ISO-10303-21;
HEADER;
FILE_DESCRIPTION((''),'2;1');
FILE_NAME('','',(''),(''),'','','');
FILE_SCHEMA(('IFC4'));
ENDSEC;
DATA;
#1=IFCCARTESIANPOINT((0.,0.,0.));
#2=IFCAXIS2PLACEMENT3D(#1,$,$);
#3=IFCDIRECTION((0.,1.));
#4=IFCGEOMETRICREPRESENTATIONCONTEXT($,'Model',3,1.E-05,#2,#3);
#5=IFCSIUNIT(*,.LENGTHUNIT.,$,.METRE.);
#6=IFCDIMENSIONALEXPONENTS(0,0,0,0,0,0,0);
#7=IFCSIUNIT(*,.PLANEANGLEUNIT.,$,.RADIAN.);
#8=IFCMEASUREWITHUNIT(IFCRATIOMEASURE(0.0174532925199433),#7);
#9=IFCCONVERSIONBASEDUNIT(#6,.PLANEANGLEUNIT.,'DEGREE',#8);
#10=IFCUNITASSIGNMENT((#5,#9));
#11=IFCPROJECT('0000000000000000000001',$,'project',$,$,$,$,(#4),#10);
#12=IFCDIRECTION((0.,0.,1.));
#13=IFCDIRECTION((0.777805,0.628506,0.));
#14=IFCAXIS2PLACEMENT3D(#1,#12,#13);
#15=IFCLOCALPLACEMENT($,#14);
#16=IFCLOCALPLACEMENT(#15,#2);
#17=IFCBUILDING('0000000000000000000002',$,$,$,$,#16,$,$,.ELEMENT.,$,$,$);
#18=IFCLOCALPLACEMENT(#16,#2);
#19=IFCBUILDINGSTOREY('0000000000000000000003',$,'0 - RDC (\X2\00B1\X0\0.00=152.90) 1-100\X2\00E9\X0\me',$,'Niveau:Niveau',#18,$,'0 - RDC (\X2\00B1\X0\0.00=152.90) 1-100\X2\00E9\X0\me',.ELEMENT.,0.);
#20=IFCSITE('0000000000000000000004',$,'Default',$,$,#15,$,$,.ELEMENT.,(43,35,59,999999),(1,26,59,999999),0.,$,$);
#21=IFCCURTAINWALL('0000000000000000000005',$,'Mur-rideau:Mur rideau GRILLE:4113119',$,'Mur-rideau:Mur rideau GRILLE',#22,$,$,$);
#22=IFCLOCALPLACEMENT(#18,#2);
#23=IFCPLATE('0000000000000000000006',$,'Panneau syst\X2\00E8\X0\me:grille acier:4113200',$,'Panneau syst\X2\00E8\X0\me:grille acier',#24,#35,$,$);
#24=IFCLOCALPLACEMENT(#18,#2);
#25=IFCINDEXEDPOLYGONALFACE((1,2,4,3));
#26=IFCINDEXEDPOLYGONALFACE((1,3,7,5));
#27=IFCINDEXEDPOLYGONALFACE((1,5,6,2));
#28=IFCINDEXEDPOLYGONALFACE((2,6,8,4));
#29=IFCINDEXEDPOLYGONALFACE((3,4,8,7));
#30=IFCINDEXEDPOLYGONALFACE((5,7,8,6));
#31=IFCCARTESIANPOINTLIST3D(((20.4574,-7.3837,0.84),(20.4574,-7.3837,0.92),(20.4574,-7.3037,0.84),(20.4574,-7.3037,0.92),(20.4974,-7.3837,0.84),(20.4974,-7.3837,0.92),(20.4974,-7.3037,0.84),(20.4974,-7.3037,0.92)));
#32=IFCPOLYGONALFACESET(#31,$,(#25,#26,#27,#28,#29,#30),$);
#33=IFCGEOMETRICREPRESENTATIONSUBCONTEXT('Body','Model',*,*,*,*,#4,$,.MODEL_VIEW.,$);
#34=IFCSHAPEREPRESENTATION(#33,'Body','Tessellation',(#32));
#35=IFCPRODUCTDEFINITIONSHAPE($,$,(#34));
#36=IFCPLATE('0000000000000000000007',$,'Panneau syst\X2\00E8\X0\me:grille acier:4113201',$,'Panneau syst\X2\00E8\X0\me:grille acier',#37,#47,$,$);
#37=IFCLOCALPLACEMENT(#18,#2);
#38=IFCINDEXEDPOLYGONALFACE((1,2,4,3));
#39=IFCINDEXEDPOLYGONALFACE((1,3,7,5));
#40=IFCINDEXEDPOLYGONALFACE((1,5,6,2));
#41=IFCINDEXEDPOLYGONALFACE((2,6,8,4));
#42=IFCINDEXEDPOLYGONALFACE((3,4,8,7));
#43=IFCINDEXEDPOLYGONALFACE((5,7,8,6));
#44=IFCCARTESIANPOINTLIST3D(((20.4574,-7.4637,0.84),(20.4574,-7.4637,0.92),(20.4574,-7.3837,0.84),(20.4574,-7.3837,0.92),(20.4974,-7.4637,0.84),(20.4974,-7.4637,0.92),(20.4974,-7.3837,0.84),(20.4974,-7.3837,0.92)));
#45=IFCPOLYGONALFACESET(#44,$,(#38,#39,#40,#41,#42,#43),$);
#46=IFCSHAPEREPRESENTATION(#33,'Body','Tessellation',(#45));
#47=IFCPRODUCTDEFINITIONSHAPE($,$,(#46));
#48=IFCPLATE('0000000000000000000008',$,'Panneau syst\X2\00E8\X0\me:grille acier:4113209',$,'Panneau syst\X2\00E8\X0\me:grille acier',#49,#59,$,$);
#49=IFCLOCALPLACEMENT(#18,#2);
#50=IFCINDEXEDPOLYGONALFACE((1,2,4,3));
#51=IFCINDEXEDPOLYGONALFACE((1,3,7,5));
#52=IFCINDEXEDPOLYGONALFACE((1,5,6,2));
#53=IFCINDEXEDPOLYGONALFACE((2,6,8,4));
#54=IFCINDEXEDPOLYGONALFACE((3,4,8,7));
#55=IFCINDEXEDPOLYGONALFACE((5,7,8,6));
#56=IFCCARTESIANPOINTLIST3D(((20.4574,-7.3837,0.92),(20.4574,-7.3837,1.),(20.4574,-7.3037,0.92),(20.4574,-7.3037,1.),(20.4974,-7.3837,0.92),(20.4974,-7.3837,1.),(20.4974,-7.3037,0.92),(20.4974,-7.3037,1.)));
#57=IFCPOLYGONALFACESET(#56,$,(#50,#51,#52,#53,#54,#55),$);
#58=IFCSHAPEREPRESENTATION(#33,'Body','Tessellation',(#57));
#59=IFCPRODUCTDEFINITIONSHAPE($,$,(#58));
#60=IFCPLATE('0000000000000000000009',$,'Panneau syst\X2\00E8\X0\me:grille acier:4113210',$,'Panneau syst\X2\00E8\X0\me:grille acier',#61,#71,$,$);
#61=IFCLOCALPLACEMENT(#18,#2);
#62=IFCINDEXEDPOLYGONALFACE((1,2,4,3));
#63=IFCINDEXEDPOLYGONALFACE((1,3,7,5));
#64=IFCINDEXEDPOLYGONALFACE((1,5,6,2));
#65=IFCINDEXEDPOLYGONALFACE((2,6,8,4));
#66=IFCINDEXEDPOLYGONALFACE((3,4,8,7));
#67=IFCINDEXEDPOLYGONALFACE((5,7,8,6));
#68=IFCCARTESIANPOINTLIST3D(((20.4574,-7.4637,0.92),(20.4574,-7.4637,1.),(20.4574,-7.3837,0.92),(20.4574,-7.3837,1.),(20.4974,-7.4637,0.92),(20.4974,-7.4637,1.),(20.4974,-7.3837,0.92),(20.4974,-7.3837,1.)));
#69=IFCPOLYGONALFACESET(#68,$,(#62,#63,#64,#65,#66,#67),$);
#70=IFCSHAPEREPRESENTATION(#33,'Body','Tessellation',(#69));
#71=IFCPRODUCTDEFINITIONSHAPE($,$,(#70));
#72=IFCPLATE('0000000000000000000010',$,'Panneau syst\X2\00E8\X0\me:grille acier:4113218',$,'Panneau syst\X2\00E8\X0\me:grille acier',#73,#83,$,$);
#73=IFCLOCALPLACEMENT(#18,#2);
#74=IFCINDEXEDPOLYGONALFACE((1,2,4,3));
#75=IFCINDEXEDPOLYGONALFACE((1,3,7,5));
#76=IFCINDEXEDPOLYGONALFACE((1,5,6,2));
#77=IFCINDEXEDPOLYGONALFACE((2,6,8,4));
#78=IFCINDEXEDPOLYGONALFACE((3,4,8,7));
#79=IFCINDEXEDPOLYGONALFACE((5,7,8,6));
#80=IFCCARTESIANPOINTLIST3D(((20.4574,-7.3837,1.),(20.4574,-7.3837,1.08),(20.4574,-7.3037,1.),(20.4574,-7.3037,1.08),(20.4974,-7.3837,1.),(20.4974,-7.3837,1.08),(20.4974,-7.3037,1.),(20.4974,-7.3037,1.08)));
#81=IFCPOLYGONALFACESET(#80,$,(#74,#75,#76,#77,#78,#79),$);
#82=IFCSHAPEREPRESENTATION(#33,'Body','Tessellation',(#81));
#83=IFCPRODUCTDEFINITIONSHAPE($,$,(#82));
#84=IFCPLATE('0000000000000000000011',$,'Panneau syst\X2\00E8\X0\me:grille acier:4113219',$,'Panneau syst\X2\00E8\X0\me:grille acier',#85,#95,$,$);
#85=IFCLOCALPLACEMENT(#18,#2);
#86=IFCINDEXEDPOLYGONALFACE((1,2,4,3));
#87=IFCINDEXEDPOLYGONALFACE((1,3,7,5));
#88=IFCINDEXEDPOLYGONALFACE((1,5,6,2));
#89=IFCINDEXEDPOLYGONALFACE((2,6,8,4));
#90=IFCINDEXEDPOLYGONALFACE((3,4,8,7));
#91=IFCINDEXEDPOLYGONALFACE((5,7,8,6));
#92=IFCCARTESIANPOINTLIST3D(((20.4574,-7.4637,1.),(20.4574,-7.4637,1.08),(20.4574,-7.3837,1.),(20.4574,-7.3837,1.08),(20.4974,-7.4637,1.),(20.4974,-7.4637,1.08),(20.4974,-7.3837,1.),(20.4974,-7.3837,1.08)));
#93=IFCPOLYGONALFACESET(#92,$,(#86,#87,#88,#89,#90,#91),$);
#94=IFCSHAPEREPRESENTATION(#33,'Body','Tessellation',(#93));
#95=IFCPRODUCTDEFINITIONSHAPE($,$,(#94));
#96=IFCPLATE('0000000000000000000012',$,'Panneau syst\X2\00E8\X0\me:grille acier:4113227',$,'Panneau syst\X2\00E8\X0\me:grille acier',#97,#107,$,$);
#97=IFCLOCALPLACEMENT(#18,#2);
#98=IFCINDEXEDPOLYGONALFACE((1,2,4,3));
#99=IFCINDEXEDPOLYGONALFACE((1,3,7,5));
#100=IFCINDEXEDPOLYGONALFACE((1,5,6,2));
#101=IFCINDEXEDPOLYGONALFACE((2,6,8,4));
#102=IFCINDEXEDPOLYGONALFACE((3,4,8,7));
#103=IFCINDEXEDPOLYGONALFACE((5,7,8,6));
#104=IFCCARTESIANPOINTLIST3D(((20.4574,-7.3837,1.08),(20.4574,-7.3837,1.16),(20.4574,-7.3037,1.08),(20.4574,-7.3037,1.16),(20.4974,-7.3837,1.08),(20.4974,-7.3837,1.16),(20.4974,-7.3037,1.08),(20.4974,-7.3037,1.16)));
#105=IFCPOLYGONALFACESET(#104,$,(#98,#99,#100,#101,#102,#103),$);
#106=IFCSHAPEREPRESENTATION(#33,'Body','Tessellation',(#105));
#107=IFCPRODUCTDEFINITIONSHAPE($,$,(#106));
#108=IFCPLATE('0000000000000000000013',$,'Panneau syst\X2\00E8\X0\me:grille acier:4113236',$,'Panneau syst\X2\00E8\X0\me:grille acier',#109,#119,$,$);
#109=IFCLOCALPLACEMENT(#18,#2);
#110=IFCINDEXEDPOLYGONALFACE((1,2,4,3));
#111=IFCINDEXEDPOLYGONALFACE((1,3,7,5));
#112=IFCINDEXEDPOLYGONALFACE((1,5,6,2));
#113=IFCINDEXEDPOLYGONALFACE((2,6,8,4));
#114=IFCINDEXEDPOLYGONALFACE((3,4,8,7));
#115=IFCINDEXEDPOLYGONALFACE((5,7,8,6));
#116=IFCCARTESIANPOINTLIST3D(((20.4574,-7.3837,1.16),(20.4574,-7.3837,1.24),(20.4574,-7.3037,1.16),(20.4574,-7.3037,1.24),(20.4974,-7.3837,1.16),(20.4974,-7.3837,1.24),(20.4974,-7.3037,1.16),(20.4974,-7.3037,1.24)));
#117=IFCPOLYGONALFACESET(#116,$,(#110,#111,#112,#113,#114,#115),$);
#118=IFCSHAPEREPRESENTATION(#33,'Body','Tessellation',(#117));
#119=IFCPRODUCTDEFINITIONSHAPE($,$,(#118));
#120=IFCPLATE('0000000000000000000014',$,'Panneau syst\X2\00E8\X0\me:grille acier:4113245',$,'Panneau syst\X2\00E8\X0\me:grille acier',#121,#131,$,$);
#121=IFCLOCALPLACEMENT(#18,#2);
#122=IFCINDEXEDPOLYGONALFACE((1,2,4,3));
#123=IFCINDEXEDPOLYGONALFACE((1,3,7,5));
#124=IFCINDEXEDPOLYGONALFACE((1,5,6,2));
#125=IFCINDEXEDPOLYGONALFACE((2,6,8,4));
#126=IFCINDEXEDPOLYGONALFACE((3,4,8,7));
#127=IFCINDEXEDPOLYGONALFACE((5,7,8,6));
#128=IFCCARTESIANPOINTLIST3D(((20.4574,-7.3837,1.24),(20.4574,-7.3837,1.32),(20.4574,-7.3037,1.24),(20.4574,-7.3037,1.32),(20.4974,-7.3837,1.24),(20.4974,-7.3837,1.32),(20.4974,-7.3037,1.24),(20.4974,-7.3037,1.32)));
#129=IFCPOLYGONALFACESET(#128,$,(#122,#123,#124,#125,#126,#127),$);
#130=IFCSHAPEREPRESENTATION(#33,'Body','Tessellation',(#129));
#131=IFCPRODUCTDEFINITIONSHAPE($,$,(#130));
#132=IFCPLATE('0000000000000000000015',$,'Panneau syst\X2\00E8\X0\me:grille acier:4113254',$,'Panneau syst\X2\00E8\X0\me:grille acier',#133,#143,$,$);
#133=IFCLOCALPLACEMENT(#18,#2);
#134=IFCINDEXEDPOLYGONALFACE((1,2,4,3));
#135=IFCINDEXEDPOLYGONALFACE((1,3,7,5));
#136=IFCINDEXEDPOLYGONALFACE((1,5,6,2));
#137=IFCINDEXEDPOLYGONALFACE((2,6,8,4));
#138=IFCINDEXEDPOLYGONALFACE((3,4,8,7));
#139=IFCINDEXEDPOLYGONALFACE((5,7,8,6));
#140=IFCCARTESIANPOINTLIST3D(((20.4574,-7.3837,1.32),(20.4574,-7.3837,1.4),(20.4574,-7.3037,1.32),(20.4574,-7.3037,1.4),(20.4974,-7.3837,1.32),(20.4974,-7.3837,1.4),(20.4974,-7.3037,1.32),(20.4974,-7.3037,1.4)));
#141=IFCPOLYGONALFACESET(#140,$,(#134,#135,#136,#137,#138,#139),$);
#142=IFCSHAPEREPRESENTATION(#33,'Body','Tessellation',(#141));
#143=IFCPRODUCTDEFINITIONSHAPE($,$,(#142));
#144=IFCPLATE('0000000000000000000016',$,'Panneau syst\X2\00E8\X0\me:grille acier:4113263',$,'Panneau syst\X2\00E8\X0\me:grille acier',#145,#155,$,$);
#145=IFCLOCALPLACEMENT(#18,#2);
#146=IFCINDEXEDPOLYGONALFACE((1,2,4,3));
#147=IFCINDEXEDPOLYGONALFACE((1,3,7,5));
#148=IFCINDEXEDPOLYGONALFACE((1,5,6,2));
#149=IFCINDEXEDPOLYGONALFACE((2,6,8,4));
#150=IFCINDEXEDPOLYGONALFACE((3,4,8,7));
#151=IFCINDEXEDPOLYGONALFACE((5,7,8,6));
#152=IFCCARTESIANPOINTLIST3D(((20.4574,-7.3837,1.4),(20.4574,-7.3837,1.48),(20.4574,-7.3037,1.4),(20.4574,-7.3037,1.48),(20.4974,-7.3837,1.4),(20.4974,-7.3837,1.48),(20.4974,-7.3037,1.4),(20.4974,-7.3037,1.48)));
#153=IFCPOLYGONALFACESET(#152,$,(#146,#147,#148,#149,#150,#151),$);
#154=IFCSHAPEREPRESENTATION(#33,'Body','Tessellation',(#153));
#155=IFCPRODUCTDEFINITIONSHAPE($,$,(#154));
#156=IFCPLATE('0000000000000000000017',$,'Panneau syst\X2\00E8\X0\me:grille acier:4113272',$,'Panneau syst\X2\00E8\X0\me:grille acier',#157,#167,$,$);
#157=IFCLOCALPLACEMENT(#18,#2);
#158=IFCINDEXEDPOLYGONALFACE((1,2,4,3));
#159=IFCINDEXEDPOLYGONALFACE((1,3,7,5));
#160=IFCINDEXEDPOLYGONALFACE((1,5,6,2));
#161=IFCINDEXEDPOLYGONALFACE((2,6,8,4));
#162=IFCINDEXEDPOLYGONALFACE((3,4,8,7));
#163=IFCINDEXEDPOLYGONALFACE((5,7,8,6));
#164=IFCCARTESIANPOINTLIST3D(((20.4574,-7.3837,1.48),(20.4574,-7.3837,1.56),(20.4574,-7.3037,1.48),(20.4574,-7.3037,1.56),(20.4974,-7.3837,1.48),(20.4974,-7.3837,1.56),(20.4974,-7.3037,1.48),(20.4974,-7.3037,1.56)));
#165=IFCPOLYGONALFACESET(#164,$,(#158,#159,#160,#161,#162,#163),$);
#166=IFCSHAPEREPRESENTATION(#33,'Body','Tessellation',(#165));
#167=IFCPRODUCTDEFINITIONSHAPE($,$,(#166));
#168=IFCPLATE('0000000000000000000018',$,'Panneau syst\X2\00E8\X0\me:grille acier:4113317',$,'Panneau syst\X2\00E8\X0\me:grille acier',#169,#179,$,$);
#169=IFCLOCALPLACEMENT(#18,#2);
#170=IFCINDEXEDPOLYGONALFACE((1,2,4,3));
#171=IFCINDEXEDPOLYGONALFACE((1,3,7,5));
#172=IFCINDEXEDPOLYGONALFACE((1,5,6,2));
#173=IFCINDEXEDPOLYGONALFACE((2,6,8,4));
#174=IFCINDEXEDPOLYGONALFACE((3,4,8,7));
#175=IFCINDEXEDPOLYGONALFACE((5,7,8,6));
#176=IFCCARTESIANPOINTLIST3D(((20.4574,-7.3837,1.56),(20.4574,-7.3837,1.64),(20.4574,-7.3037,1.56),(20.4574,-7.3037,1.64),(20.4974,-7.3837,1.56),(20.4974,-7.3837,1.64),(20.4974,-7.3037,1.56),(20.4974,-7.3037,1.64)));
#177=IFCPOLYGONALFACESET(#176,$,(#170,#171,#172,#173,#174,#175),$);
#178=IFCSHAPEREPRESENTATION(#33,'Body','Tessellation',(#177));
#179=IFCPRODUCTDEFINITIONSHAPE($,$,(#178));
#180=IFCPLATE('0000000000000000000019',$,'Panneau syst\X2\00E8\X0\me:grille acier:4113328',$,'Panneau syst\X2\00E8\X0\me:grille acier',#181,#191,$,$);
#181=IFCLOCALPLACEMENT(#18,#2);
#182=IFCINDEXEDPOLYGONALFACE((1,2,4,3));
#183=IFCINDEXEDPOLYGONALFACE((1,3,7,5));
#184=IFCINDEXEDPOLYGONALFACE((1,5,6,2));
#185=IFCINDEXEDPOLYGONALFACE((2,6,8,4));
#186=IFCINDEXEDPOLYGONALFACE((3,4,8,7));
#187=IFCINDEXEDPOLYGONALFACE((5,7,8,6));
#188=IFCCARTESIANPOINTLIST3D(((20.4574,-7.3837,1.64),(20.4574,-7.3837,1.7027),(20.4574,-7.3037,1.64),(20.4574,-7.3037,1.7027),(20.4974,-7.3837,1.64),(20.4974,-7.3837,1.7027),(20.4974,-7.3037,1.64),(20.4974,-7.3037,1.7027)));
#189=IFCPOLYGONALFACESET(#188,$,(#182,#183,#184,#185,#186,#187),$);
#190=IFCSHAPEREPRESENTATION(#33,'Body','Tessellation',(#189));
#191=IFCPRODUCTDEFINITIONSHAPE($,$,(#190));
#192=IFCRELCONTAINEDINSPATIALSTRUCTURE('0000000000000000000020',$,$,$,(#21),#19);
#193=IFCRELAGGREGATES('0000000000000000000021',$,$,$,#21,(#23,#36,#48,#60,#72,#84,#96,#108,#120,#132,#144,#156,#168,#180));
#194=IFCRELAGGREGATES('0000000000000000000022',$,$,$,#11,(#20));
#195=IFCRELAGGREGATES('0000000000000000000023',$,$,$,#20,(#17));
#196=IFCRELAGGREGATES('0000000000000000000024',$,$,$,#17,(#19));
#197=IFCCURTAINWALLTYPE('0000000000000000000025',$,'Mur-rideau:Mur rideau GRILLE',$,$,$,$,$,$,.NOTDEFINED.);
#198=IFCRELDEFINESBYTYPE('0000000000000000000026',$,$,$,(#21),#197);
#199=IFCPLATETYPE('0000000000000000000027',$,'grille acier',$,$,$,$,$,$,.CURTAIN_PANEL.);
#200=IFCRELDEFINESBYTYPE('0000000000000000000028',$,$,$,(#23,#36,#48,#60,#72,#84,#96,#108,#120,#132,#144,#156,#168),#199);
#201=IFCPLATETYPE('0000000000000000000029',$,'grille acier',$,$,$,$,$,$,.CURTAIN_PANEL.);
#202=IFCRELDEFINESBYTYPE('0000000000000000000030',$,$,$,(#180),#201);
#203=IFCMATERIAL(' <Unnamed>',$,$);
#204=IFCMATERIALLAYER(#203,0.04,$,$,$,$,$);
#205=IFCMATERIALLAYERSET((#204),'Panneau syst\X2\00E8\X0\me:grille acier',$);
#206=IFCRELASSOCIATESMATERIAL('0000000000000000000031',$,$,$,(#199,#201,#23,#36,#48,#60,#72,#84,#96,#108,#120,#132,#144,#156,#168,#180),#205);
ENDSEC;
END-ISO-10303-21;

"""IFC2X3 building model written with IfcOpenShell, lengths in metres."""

from ifc_helpers import new_model, entity, si_unit, converted_unit, direction, frame, origin, origin_2d_with_axis, place, context, subcontext, project, spatial, rectangle, extrude, source, transform, mapped, material, layer, layer_set, layer_usage, type_object, type_shapes, element, aggregate, save


model = new_model("IFC2X3")

# Units and contexts
model_context = context("Model", 3, precision=1e-05, world=origin(), true_north=direction((0.0, 1.0)))
body_context = subcontext(model_context, "Body", "Model", "MODEL_VIEW")
ifc_project = project(units=[si_unit("LENGTHUNIT", "METRE"), converted_unit("PLANEANGLEUNIT", "DEGREE", entity("IfcRatioMeasure", 0.0174532925199433), si_unit("PLANEANGLEUNIT", "RADIAN"), dimensions=[0, 0, 0, 0, 0, 0, 0])], contexts=[model_context])

# Site, building, storey
site_placement = place(None, frame((0.0, 0.0, 0.0), z_axis=(0.0, 0.0, 1.0), x_axis=(0.777805, 0.628506, 0.0)))
site = spatial("IfcSite", under=ifc_project, at=site_placement, Name="Default", CompositionType="ELEMENT", RefLatitude=(43, 35, 59, 999999), RefLongitude=(1, 26, 59, 999999), RefElevation=0.0)
building_placement = place(site_placement, origin())
building = spatial("IfcBuilding", under=site, at=building_placement, CompositionType="ELEMENT")
storey_placement = place(building_placement, origin())
storey = spatial("IfcBuildingStorey", under=building, at=storey_placement, Name="0 - RDC (±0.00=152.90) 1-100éme", ObjectType="Niveau:Niveau", LongName="0 - RDC (±0.00=152.90) 1-100éme", CompositionType="ELEMENT", Elevation=0.0)

# Curtain wall, plates
curtain_wall_type = type_object("IfcCurtainWallType", Name="Mur-rideau:Mur rideau GRILLE", PredefinedType="NOTDEFINED")
curtain_wall_placement = place(storey_placement, origin())
curtain_wall = element("IfcCurtainWall", 1, at=curtain_wall_placement, inside=storey, type_object=curtain_wall_type, Name="Mur-rideau:Mur rideau GRILLE:4113119", ObjectType="Mur-rideau:Mur rideau GRILLE")
ifc_material = material(Name=" <Unnamed>")
ifc_layer = layer(ifc_material, 0.04)
ifc_layer_set = layer_set([ifc_layer], Name="Panneau système:grille acier")
plate_type_1 = type_object("IfcPlateType", Name="grille acier", PredefinedType="CURTAIN_PANEL", material=ifc_layer_set)
shared_shape_1 = source(origin(), body_context, "Body", "SweptSolid", [
    extrude(rectangle(XDim=0.04, YDim=0.08, at=origin_2d_with_axis()), frame((0.0, 0.0, 0.0), z_axis=(0.0, 0.0, 1.0), x_axis=(0.0, 1.0, 0.0)), (0.0, 0.0, 1.0), 0.08),
])
type_shapes(plate_type_1, [shared_shape_1])
ifc_layer_usage_1 = layer_usage(ifc_layer_set, "AXIS3", "POSITIVE", 0.0)
plate_1_placement = place(curtain_wall_placement, frame((20.4774, -7.3437, 0.84), z_axis=(0.0, 0.0, 1.0), x_axis=(0.0, -1.0, 0.0)))
plate_1 = element("IfcPlate", 2, at=plate_1_placement, type_object=plate_type_1, material=ifc_layer_usage_1, Name="Panneau système:grille acier:4113200", ObjectType="Panneau système:grille acier", context=body_context, shape_type="MappedRepresentation", body=[
    mapped(shared_shape_1, transform((0.0, 0.0, 0.0), scale=1.0)),
])
ifc_layer_usage_2 = layer_usage(ifc_layer_set, "AXIS3", "POSITIVE", 0.0)
plate_2_placement = place(curtain_wall_placement, frame((20.4774, -7.4237, 0.84), z_axis=(0.0, 0.0, 1.0), x_axis=(0.0, -1.0, 0.0)))
plate_2 = element("IfcPlate", 3, at=plate_2_placement, type_object=plate_type_1, material=ifc_layer_usage_2, Name="Panneau système:grille acier:4113201", ObjectType="Panneau système:grille acier", context=body_context, shape_type="MappedRepresentation", body=[
    mapped(shared_shape_1, transform((0.0, 0.0, 0.0), scale=1.0)),
])
ifc_layer_usage_3 = layer_usage(ifc_layer_set, "AXIS3", "POSITIVE", 0.0)
plate_3_placement = place(curtain_wall_placement, frame((20.4774, -7.3437, 0.92), z_axis=(0.0, 0.0, 1.0), x_axis=(0.0, -1.0, 0.0)))
plate_3 = element("IfcPlate", 4, at=plate_3_placement, type_object=plate_type_1, material=ifc_layer_usage_3, Name="Panneau système:grille acier:4113209", ObjectType="Panneau système:grille acier", context=body_context, shape_type="MappedRepresentation", body=[
    mapped(shared_shape_1, transform((0.0, 0.0, 0.0), scale=1.0)),
])
ifc_layer_usage_4 = layer_usage(ifc_layer_set, "AXIS3", "POSITIVE", 0.0)
plate_4_placement = place(curtain_wall_placement, frame((20.4774, -7.4237, 0.92), z_axis=(0.0, 0.0, 1.0), x_axis=(0.0, -1.0, 0.0)))
plate_4 = element("IfcPlate", 5, at=plate_4_placement, type_object=plate_type_1, material=ifc_layer_usage_4, Name="Panneau système:grille acier:4113210", ObjectType="Panneau système:grille acier", context=body_context, shape_type="MappedRepresentation", body=[
    mapped(shared_shape_1, transform((0.0, 0.0, 0.0), scale=1.0)),
])
ifc_layer_usage_5 = layer_usage(ifc_layer_set, "AXIS3", "POSITIVE", 0.0)
plate_5_placement = place(curtain_wall_placement, frame((20.4774, -7.3437, 1.0), z_axis=(0.0, 0.0, 1.0), x_axis=(0.0, -1.0, 0.0)))
plate_5 = element("IfcPlate", 6, at=plate_5_placement, type_object=plate_type_1, material=ifc_layer_usage_5, Name="Panneau système:grille acier:4113218", ObjectType="Panneau système:grille acier", context=body_context, shape_type="MappedRepresentation", body=[
    mapped(shared_shape_1, transform((0.0, 0.0, 0.0), scale=1.0)),
])
ifc_layer_usage_6 = layer_usage(ifc_layer_set, "AXIS3", "POSITIVE", 0.0)
plate_6_placement = place(curtain_wall_placement, frame((20.4774, -7.4237, 1.0), z_axis=(0.0, 0.0, 1.0), x_axis=(0.0, -1.0, 0.0)))
plate_6 = element("IfcPlate", 7, at=plate_6_placement, type_object=plate_type_1, material=ifc_layer_usage_6, Name="Panneau système:grille acier:4113219", ObjectType="Panneau système:grille acier", context=body_context, shape_type="MappedRepresentation", body=[
    mapped(shared_shape_1, transform((0.0, 0.0, 0.0), scale=1.0)),
])
ifc_layer_usage_7 = layer_usage(ifc_layer_set, "AXIS3", "POSITIVE", 0.0)
plate_7_placement = place(curtain_wall_placement, frame((20.4774, -7.3437, 1.08), z_axis=(0.0, 0.0, 1.0), x_axis=(0.0, -1.0, 0.0)))
plate_7 = element("IfcPlate", 8, at=plate_7_placement, type_object=plate_type_1, material=ifc_layer_usage_7, Name="Panneau système:grille acier:4113227", ObjectType="Panneau système:grille acier", context=body_context, shape_type="MappedRepresentation", body=[
    mapped(shared_shape_1, transform((0.0, 0.0, 0.0), scale=1.0)),
])
ifc_layer_usage_8 = layer_usage(ifc_layer_set, "AXIS3", "POSITIVE", 0.0)
plate_8_placement = place(curtain_wall_placement, frame((20.4774, -7.3437, 1.16), z_axis=(0.0, 0.0, 1.0), x_axis=(0.0, -1.0, 0.0)))
plate_8 = element("IfcPlate", 9, at=plate_8_placement, type_object=plate_type_1, material=ifc_layer_usage_8, Name="Panneau système:grille acier:4113236", ObjectType="Panneau système:grille acier", context=body_context, shape_type="MappedRepresentation", body=[
    mapped(shared_shape_1, transform((0.0, 0.0, 0.0), scale=1.0)),
])
ifc_layer_usage_9 = layer_usage(ifc_layer_set, "AXIS3", "POSITIVE", 0.0)
plate_9_placement = place(curtain_wall_placement, frame((20.4774, -7.3437, 1.24), z_axis=(0.0, 0.0, 1.0), x_axis=(0.0, -1.0, 0.0)))
plate_9 = element("IfcPlate", 10, at=plate_9_placement, type_object=plate_type_1, material=ifc_layer_usage_9, Name="Panneau système:grille acier:4113245", ObjectType="Panneau système:grille acier", context=body_context, shape_type="MappedRepresentation", body=[
    mapped(shared_shape_1, transform((0.0, 0.0, 0.0), scale=1.0)),
])
ifc_layer_usage_10 = layer_usage(ifc_layer_set, "AXIS3", "POSITIVE", 0.0)
plate_10_placement = place(curtain_wall_placement, frame((20.4774, -7.3437, 1.32), z_axis=(0.0, 0.0, 1.0), x_axis=(0.0, -1.0, 0.0)))
plate_10 = element("IfcPlate", 11, at=plate_10_placement, type_object=plate_type_1, material=ifc_layer_usage_10, Name="Panneau système:grille acier:4113254", ObjectType="Panneau système:grille acier", context=body_context, shape_type="MappedRepresentation", body=[
    mapped(shared_shape_1, transform((0.0, 0.0, 0.0), scale=1.0)),
])
ifc_layer_usage_11 = layer_usage(ifc_layer_set, "AXIS3", "POSITIVE", 0.0)
plate_11_placement = place(curtain_wall_placement, frame((20.4774, -7.3437, 1.4), z_axis=(0.0, 0.0, 1.0), x_axis=(0.0, -1.0, 0.0)))
plate_11 = element("IfcPlate", 12, at=plate_11_placement, type_object=plate_type_1, material=ifc_layer_usage_11, Name="Panneau système:grille acier:4113263", ObjectType="Panneau système:grille acier", context=body_context, shape_type="MappedRepresentation", body=[
    mapped(shared_shape_1, transform((0.0, 0.0, 0.0), scale=1.0)),
])
ifc_layer_usage_12 = layer_usage(ifc_layer_set, "AXIS3", "POSITIVE", 0.0)
plate_12_placement = place(curtain_wall_placement, frame((20.4774, -7.3437, 1.48), z_axis=(0.0, 0.0, 1.0), x_axis=(0.0, -1.0, 0.0)))
plate_12 = element("IfcPlate", 13, at=plate_12_placement, type_object=plate_type_1, material=ifc_layer_usage_12, Name="Panneau système:grille acier:4113272", ObjectType="Panneau système:grille acier", context=body_context, shape_type="MappedRepresentation", body=[
    mapped(shared_shape_1, transform((0.0, 0.0, 0.0), scale=1.0)),
])
ifc_layer_usage_13 = layer_usage(ifc_layer_set, "AXIS3", "POSITIVE", 0.0)
plate_13_placement = place(curtain_wall_placement, frame((20.4774, -7.3437, 1.56), z_axis=(0.0, 0.0, 1.0), x_axis=(0.0, -1.0, 0.0)))
plate_13 = element("IfcPlate", 14, at=plate_13_placement, type_object=plate_type_1, material=ifc_layer_usage_13, Name="Panneau système:grille acier:4113317", ObjectType="Panneau système:grille acier", context=body_context, shape_type="MappedRepresentation", body=[
    mapped(shared_shape_1, transform((0.0, 0.0, 0.0), scale=1.0)),
])
ifc_layer_usage_14 = layer_usage(ifc_layer_set, "AXIS3", "POSITIVE", 0.0)
plate_type_2 = type_object("IfcPlateType", Name="grille acier", PredefinedType="CURTAIN_PANEL", material=ifc_layer_set)
shared_shape_2 = source(origin(), body_context, "Body", "SweptSolid", [
    extrude(rectangle(XDim=0.04, YDim=0.08, at=origin_2d_with_axis()), frame((0.0, 0.0, 0.0), z_axis=(0.0, 0.0, 1.0), x_axis=(0.0, 1.0, 0.0)), (0.0, 0.0, 1.0), 0.0627),
])
type_shapes(plate_type_2, [shared_shape_2])
plate_14_placement = place(curtain_wall_placement, frame((20.4774, -7.3437, 1.64), z_axis=(0.0, 0.0, 1.0), x_axis=(0.0, -1.0, 0.0)))
plate_14 = element("IfcPlate", 15, at=plate_14_placement, type_object=plate_type_2, material=ifc_layer_usage_14, Name="Panneau système:grille acier:4113328", ObjectType="Panneau système:grille acier", context=body_context, shape_type="MappedRepresentation", body=[
    mapped(shared_shape_2, transform((0.0, 0.0, 0.0), scale=1.0)),
])
aggregate(curtain_wall, [plate_1, plate_2, plate_3, plate_4, plate_5, plate_6, plate_7, plate_8, plate_9, plate_10, plate_11, plate_12, plate_13, plate_14])

save(model, "model.ifc")
